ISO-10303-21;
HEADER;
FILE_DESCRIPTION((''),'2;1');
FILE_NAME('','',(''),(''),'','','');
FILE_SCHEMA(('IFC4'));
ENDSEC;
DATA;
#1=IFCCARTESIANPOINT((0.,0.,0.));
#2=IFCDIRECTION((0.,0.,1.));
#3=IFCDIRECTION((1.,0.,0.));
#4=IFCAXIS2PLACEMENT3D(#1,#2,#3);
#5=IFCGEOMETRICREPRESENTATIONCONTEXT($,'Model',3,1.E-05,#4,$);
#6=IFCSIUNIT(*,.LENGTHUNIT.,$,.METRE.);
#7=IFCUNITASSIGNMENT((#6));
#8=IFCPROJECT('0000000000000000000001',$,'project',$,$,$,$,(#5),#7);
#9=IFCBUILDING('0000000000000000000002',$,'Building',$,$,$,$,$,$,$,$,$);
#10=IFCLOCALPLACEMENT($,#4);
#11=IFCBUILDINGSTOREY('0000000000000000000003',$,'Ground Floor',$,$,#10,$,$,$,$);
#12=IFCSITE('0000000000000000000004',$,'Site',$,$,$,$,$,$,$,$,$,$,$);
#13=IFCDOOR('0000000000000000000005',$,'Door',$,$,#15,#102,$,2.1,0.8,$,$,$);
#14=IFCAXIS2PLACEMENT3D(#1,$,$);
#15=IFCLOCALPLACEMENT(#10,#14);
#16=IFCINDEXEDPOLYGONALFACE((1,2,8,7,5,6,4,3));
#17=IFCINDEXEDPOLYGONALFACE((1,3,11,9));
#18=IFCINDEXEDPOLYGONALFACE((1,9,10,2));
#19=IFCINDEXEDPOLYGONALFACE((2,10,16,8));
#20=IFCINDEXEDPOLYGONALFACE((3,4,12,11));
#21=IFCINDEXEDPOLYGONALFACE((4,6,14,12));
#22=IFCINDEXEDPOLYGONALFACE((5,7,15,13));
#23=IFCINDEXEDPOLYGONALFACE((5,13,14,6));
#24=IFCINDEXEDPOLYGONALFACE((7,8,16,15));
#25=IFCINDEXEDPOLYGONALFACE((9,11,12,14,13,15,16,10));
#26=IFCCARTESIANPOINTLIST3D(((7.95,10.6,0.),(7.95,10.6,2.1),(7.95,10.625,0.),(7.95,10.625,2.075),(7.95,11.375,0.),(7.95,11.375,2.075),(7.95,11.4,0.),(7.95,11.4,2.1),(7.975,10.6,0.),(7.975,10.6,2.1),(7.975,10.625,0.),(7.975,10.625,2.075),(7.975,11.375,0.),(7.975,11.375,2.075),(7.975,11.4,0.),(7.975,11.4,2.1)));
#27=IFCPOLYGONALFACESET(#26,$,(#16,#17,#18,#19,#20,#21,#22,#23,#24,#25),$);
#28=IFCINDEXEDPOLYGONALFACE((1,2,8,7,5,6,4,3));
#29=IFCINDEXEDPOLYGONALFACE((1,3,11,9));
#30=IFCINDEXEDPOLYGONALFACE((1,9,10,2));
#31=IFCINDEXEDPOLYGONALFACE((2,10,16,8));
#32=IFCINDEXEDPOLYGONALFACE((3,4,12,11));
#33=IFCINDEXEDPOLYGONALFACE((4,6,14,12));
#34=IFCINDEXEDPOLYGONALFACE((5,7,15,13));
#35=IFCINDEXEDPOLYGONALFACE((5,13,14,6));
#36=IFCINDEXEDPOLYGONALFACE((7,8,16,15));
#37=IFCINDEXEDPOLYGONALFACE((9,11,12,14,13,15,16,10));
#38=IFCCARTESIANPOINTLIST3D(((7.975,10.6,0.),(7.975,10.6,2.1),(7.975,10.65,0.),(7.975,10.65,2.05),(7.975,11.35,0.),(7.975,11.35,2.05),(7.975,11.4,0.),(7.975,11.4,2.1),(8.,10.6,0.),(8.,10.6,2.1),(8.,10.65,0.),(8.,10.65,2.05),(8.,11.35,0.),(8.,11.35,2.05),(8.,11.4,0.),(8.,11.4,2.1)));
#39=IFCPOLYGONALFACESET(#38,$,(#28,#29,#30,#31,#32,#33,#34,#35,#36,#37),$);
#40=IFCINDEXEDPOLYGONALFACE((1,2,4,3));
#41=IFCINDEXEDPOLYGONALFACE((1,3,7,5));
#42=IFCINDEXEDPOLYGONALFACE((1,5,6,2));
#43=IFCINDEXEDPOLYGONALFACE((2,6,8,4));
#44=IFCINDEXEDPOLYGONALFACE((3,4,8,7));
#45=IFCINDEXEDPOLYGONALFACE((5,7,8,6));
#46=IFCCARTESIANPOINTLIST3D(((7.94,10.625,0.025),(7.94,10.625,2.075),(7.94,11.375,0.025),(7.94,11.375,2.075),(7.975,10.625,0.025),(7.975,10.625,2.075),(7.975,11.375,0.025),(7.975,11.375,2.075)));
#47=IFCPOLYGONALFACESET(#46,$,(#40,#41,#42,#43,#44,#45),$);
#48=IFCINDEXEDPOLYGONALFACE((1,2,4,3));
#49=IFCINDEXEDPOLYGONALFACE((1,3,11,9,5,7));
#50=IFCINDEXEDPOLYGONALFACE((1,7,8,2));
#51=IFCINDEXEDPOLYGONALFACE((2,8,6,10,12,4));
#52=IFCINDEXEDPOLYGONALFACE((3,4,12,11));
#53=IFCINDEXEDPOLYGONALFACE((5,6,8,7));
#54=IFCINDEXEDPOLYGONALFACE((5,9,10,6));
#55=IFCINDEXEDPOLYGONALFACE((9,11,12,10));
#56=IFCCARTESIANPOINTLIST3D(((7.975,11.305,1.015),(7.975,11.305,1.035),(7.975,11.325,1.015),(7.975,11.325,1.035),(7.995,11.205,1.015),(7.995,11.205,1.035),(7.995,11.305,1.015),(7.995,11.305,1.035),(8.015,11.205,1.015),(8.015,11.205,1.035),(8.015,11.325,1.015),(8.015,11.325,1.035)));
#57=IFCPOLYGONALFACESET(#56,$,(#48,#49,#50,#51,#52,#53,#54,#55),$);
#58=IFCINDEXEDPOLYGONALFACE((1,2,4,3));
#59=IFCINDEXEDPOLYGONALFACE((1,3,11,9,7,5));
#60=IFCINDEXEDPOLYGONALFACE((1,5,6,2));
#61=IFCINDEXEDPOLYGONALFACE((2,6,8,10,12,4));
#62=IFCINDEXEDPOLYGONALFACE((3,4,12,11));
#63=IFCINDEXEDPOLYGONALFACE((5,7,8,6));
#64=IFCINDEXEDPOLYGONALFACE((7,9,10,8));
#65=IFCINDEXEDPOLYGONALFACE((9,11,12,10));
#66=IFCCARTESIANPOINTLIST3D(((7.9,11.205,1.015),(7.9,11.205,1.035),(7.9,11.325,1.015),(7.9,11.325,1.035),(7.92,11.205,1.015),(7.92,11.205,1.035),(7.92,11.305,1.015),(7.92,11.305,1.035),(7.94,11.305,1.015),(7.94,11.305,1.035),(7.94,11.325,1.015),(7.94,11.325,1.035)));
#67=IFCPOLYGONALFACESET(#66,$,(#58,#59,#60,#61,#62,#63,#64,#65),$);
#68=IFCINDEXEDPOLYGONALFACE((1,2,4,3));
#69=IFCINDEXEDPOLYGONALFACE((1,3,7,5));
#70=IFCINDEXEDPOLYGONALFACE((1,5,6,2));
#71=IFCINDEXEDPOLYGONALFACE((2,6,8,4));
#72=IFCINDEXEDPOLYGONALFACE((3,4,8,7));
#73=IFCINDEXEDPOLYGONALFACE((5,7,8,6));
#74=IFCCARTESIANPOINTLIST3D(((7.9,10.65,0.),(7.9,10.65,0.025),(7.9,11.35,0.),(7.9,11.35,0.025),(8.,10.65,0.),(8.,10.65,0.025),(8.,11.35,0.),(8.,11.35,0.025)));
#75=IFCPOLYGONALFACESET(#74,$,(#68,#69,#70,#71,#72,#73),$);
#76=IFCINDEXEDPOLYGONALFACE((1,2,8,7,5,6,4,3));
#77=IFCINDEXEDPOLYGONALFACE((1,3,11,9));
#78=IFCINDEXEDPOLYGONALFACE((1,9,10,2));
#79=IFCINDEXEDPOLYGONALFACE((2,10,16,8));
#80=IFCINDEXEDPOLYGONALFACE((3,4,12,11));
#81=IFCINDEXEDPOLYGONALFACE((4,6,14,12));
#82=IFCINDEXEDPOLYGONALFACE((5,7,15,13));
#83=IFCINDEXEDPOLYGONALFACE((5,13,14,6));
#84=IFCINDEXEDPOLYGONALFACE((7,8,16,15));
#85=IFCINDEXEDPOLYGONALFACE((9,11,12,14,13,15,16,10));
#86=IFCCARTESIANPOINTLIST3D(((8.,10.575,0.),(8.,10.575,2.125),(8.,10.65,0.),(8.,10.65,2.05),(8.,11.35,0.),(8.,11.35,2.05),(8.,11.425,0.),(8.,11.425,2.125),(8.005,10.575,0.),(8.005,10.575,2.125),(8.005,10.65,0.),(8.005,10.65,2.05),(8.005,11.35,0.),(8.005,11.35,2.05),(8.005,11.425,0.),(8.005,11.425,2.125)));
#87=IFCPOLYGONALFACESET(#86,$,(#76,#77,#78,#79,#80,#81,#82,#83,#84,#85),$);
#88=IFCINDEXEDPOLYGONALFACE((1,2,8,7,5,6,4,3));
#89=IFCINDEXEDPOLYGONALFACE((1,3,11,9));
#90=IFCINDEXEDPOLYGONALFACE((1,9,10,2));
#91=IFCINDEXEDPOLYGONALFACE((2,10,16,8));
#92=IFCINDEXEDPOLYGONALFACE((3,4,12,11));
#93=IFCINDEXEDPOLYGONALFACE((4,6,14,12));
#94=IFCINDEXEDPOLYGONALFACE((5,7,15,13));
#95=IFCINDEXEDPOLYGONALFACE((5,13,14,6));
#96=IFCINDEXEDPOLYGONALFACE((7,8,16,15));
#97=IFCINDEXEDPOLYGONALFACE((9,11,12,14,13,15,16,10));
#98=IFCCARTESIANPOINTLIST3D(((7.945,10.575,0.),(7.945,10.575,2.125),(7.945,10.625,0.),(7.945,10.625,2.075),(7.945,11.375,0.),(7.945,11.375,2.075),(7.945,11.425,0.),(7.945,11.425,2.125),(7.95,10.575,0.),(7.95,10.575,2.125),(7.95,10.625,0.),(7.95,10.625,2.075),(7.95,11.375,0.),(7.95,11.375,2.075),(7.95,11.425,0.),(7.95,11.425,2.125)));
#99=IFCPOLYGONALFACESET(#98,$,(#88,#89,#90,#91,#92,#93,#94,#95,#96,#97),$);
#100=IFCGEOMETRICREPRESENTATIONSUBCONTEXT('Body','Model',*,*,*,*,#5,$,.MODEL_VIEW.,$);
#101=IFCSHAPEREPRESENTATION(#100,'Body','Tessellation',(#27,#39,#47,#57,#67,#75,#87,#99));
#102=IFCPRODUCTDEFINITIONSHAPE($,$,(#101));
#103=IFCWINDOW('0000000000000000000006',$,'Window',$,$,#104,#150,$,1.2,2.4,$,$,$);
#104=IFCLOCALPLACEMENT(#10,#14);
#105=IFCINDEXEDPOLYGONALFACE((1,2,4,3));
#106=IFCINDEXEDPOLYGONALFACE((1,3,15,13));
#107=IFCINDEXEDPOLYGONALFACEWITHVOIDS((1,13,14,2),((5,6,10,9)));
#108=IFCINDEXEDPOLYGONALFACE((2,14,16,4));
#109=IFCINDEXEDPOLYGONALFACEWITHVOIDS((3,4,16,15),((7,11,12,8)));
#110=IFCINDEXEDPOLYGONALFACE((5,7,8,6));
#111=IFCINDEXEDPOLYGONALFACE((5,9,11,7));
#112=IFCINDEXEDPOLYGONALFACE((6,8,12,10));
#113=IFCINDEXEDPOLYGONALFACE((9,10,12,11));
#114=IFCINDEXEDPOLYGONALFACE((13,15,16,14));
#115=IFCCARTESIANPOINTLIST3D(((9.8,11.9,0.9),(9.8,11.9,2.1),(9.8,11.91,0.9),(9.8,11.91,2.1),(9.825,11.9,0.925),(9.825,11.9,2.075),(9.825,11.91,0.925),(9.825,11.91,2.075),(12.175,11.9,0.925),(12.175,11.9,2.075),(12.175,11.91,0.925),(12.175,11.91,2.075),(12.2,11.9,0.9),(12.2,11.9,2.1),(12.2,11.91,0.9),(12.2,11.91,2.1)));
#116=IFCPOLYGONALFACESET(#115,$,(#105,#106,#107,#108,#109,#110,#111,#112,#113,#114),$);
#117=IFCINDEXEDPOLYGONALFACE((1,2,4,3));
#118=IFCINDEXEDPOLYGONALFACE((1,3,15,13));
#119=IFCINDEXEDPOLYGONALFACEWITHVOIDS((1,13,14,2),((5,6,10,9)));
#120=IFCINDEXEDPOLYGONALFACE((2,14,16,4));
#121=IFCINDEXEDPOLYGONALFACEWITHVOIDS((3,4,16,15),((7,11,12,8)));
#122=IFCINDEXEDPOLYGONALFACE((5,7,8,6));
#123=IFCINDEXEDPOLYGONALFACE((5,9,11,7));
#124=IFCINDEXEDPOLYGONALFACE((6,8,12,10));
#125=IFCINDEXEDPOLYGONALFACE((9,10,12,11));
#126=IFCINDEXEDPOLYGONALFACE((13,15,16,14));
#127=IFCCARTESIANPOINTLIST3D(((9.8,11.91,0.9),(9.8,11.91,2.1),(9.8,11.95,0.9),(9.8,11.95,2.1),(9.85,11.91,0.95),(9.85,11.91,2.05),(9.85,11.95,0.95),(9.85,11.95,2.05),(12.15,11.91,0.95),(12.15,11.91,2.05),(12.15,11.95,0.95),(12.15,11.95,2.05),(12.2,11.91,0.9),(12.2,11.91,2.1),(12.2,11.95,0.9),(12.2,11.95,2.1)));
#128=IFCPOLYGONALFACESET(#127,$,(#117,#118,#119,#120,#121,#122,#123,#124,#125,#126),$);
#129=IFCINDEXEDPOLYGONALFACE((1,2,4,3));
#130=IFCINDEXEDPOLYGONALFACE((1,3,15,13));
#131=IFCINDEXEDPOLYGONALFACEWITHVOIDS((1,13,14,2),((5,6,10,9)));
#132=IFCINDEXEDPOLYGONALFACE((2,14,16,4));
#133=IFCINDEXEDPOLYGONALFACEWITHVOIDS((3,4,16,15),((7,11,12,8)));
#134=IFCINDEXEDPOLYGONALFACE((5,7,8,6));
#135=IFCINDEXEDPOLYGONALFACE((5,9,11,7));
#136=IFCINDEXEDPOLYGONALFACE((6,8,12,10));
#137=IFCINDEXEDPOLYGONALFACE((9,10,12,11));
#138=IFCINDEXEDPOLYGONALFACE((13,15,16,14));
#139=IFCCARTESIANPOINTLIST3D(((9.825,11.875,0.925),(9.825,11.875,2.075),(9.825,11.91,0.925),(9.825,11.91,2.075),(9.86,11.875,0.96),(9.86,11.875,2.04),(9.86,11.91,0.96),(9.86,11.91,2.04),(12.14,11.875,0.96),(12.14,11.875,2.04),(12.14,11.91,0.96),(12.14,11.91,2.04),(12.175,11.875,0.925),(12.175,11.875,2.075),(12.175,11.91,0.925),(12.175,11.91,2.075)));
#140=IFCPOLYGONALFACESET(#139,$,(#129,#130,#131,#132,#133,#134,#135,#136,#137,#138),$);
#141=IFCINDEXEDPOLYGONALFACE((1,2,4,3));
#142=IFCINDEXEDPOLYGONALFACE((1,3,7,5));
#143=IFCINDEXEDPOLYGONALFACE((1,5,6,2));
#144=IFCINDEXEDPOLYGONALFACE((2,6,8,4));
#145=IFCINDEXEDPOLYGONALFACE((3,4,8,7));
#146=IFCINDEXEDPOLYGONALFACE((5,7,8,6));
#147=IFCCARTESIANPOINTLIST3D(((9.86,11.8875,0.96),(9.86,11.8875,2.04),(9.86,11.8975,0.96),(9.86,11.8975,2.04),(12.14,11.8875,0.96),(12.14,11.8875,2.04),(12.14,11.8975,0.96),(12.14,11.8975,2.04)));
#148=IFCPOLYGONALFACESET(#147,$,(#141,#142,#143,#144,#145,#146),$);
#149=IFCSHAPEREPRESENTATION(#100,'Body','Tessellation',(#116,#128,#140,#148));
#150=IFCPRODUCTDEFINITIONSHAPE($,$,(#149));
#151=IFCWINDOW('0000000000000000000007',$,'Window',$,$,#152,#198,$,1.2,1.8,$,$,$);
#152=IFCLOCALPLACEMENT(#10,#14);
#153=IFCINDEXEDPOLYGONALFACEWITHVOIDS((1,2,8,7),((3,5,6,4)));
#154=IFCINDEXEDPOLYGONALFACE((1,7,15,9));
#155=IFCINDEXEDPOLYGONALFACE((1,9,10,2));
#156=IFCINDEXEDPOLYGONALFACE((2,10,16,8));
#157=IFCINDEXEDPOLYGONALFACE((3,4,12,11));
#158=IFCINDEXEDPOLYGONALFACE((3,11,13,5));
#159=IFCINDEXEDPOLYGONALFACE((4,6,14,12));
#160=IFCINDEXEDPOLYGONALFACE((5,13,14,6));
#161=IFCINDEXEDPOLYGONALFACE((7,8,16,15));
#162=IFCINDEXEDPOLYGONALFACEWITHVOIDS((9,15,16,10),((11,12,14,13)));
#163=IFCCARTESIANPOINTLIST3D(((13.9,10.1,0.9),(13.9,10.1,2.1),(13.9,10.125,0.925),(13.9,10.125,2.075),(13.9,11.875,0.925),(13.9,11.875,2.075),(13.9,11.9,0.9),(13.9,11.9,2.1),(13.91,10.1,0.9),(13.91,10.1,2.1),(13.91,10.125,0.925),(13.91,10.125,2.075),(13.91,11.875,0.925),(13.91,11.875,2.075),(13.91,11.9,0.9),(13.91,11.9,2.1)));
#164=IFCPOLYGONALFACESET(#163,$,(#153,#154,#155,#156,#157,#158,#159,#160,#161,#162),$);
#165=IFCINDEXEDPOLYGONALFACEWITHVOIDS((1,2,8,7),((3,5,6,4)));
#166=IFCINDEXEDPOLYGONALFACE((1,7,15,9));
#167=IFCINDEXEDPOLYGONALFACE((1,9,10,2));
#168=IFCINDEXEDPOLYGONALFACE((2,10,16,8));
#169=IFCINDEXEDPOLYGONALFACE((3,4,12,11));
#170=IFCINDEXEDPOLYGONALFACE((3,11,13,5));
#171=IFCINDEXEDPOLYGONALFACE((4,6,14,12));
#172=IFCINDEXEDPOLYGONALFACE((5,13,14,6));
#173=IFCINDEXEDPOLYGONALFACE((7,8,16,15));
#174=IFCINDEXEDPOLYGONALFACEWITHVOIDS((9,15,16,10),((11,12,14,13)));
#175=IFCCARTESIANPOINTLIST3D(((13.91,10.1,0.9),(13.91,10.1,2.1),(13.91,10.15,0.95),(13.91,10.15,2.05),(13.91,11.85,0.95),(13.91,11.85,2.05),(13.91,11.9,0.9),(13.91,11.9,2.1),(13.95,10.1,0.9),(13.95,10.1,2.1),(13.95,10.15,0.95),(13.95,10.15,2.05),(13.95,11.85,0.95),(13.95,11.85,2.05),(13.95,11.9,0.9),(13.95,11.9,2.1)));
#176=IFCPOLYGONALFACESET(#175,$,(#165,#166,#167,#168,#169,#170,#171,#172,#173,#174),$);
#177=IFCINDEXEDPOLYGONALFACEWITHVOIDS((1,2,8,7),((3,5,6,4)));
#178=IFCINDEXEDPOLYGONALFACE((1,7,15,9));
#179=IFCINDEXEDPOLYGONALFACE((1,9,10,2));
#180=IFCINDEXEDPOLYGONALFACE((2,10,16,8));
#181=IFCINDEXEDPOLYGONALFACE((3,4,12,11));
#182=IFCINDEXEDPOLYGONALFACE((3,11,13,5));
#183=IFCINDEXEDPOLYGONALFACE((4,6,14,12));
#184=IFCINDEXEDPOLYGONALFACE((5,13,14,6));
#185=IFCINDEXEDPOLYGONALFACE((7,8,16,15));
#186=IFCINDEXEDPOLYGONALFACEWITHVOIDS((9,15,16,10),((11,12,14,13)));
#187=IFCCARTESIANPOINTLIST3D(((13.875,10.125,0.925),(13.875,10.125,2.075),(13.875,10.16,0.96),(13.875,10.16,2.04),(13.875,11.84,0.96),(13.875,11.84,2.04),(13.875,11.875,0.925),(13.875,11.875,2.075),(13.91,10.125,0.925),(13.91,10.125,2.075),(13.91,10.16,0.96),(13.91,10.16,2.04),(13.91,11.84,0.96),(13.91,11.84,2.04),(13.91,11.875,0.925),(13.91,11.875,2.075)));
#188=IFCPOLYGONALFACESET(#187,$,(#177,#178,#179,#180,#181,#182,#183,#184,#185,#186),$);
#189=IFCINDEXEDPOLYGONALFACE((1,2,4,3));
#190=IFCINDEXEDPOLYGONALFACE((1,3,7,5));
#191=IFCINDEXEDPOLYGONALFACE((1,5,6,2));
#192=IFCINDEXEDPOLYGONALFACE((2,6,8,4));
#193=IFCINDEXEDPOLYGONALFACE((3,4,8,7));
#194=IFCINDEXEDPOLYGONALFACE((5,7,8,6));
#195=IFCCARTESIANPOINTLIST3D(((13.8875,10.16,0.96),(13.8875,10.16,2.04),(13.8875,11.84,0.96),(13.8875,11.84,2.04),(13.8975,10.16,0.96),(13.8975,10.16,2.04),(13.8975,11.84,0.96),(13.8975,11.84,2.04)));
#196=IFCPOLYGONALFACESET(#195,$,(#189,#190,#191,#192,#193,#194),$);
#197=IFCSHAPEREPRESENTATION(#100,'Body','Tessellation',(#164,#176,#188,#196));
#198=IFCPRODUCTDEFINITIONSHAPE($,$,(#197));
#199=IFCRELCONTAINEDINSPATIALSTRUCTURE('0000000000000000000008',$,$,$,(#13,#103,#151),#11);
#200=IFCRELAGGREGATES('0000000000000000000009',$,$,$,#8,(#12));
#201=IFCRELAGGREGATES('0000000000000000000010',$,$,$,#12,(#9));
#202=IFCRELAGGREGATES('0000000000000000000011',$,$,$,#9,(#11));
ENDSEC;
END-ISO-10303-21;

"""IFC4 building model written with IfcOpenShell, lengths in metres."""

from ifc_helpers import new_model, si_unit, frame, origin_with_axes, place, context, subcontext, project, spatial, line, indexed_curve, outline, extrude, element, save


model = new_model("IFC4")

# Units and contexts
model_context = context("Model", 3, precision=1e-05, world=origin_with_axes())
body_context = subcontext(model_context, "Body", "Model", "MODEL_VIEW")
ifc_project = project(units=[si_unit("LENGTHUNIT", "METRE")], contexts=[model_context])

# Site, building, storey
site = spatial("IfcSite", under=ifc_project, Name="Site")
building = spatial("IfcBuilding", under=site, Name="Building")
storey_placement = place(None, origin_with_axes())
storey = spatial("IfcBuildingStorey", under=building, at=storey_placement, Name="Ground Floor")

# Door
door_1_placement = place(storey_placement, frame((8.0, 10.6, 0.0), z_axis=(0.0, 0.0, 1.0), x_axis=(0.0, 1.0, 0.0)))
element("IfcDoor", 1, at=door_1_placement, inside=storey, Name="Door", OverallHeight=2.1, OverallWidth=0.8, context=body_context, shape_type="SweptSolid", body=[
    extrude(outline(indexed_curve([(0.0, 0.0), (0.0, 2.1), (0.8, 2.1), (0.8, 0.0), (0.775, 0.0), (0.775, 2.075), (0.025, 2.075), (0.025, 0.0)], segments=[line(1, 2, 3, 4, 5, 6, 7, 8, 1)])), frame((0.0, 0.025, 0.0), z_axis=(0.0, -1.0, 0.0), x_axis=(1.0, 0.0, 0.0)), (0.0, 0.0, -1.0), 0.025),
    extrude(outline(indexed_curve([(0.0, 0.0), (0.0, 2.1), (0.8, 2.1), (0.8, 0.0), (0.75, 0.0), (0.75, 2.05), (0.05, 2.05), (0.05, 0.0)], segments=[line(1, 2, 3, 4, 5, 6, 7, 8, 1)])), frame((0.0, 0.0, 0.0), z_axis=(0.0, -1.0, 0.0), x_axis=(1.0, 0.0, 0.0)), (0.0, 0.0, -1.0), 0.025),
    extrude(outline(indexed_curve([(0.0, 0.0), (0.75, 0.0), (0.75, 0.035), (0.0, 0.035)], segments=[line(1, 2, 3, 4, 1)])), frame((0.025, 0.025, 0.025), z_axis=(0.0, 0.0, 1.0), x_axis=(1.0, 0.0, 0.0)), (0.0, 0.0, 1.0), 2.05),
    extrude(outline(indexed_curve([(0.0, 0.0), (0.0, -0.04), (-0.12, -0.04), (-0.12, -0.02), (-0.02, -0.02), (-0.02, 0.0)], segments=[line(1, 2, 3, 4, 5, 6, 1)])), frame((0.725, 0.025, 1.015), z_axis=(0.0, 0.0, 1.0), x_axis=(1.0, 0.0, 0.0)), (0.0, 0.0, 1.0), 0.02),
    extrude(outline(indexed_curve([(0.0, 0.0), (0.0, 0.04), (-0.12, 0.04), (-0.12, 0.02), (-0.02, 0.02), (-0.02, 0.0)], segments=[line(1, 2, 3, 4, 5, 6, 1)])), frame((0.725, 0.06, 1.015), z_axis=(0.0, 0.0, 1.0), x_axis=(1.0, 0.0, 0.0)), (0.0, 0.0, 1.0), 0.02),
    extrude(outline(indexed_curve([(0.0, 0.0), (0.7, 0.0), (0.7, 0.1), (0.0, 0.1)], segments=[line(1, 2, 3, 4, 1)])), frame((0.05, 0.0, 0.0), z_axis=(0.0, 0.0, 1.0), x_axis=(1.0, 0.0, 0.0)), (0.0, 0.0, 1.0), 0.025),
    extrude(outline(indexed_curve([(0.0, 0.0), (0.0, 2.125), (0.85, 2.125), (0.85, 0.0), (0.775, 0.0), (0.775, 2.05), (0.075, 2.05), (0.075, 0.0)], segments=[line(1, 2, 3, 4, 5, 6, 7, 8, 1)])), frame((-0.025, -0.005, 0.0), z_axis=(0.0, -1.0, 0.0), x_axis=(1.0, 0.0, 0.0)), (0.0, 0.0, -1.0), 0.005),
    extrude(outline(indexed_curve([(0.0, 0.0), (0.0, 2.125), (0.85, 2.125), (0.85, 0.0), (0.8, 0.0), (0.8, 2.075), (0.05, 2.075), (0.05, 0.0)], segments=[line(1, 2, 3, 4, 5, 6, 7, 8, 1)])), frame((-0.025, 0.05, 0.0), z_axis=(0.0, -1.0, 0.0), x_axis=(1.0, 0.0, 0.0)), (0.0, 0.0, -1.0), 0.005),
])

# Windows
window_1_placement = place(storey_placement, frame((12.2, 12.0, 0.9), z_axis=(0.0, 0.0, 1.0), x_axis=(-1.0, 0.0, 0.0)))
element("IfcWindow", 2, at=window_1_placement, inside=storey, Name="Window", OverallHeight=1.2, OverallWidth=2.4, context=body_context, shape_type="SweptSolid", body=[
    extrude(outline(indexed_curve([(0.0, 0.0), (2.4, 0.0), (2.4, 1.2), (0.0, 1.2)], segments=[line(1, 2, 3, 4, 1)]), holes=[indexed_curve([(0.025, 0.025), (2.375, 0.025), (2.375, 1.175), (0.025, 1.175)], segments=[line(1, 2, 3, 4, 1)])]), frame((0.0, 0.09, 0.0), z_axis=(0.0, -1.0, 0.0), x_axis=(1.0, 0.0, 0.0)), (0.0, 0.0, -1.0), 0.01),
    extrude(outline(indexed_curve([(0.0, 0.0), (2.4, 0.0), (2.4, 1.2), (0.0, 1.2)], segments=[line(1, 2, 3, 4, 1)]), holes=[indexed_curve([(0.05, 0.05), (2.35, 0.05), (2.35, 1.15), (0.05, 1.15)], segments=[line(1, 2, 3, 4, 1)])]), frame((0.0, 0.05, 0.0), z_axis=(0.0, -1.0, 0.0), x_axis=(1.0, 0.0, 0.0)), (0.0, 0.0, -1.0), 0.04),
    extrude(outline(indexed_curve([(0.0, 0.0), (2.35, 0.0), (2.35, 1.15), (0.0, 1.15)], segments=[line(1, 2, 3, 4, 1)]), holes=[indexed_curve([(0.035, 0.035), (2.315, 0.035), (2.315, 1.115), (0.035, 1.115)], segments=[line(1, 2, 3, 4, 1)])]), frame((0.025, 0.09, 0.025), z_axis=(0.0, -1.0, 0.0), x_axis=(1.0, 0.0, 0.0)), (0.0, 0.0, -1.0), 0.035),
    extrude(outline(indexed_curve([(0.035, 0.035), (2.315, 0.035), (2.315, 1.115), (0.035, 1.115)], segments=[line(1, 2, 3, 4, 1)])), frame((0.025, 0.1025, 0.025), z_axis=(0.0, -1.0, 0.0), x_axis=(1.0, 0.0, 0.0)), (0.0, 0.0, -1.0), 0.01),
])
window_2_placement = place(storey_placement, frame((14.0, 10.1, 0.9), z_axis=(0.0, 0.0, 1.0), x_axis=(0.0, 1.0, 0.0)))
element("IfcWindow", 3, at=window_2_placement, inside=storey, Name="Window", OverallHeight=1.2, OverallWidth=1.8, context=body_context, shape_type="SweptSolid", body=[
    extrude(outline(indexed_curve([(0.0, 0.0), (1.8, 0.0), (1.8, 1.2), (0.0, 1.2)], segments=[line(1, 2, 3, 4, 1)]), holes=[indexed_curve([(0.025, 0.025), (1.775, 0.025), (1.775, 1.175), (0.025, 1.175)], segments=[line(1, 2, 3, 4, 1)])]), frame((0.0, 0.09, 0.0), z_axis=(0.0, -1.0, 0.0), x_axis=(1.0, 0.0, 0.0)), (0.0, 0.0, -1.0), 0.01),
    extrude(outline(indexed_curve([(0.0, 0.0), (1.8, 0.0), (1.8, 1.2), (0.0, 1.2)], segments=[line(1, 2, 3, 4, 1)]), holes=[indexed_curve([(0.05, 0.05), (1.75, 0.05), (1.75, 1.15), (0.05, 1.15)], segments=[line(1, 2, 3, 4, 1)])]), frame((0.0, 0.05, 0.0), z_axis=(0.0, -1.0, 0.0), x_axis=(1.0, 0.0, 0.0)), (0.0, 0.0, -1.0), 0.04),
    extrude(outline(indexed_curve([(0.0, 0.0), (1.75, 0.0), (1.75, 1.15), (0.0, 1.15)], segments=[line(1, 2, 3, 4, 1)]), holes=[indexed_curve([(0.035, 0.035), (1.715, 0.035), (1.715, 1.115), (0.035, 1.115)], segments=[line(1, 2, 3, 4, 1)])]), frame((0.025, 0.09, 0.025), z_axis=(0.0, -1.0, 0.0), x_axis=(1.0, 0.0, 0.0)), (0.0, 0.0, -1.0), 0.035),
    extrude(outline(indexed_curve([(0.035, 0.035), (1.715, 0.035), (1.715, 1.115), (0.035, 1.115)], segments=[line(1, 2, 3, 4, 1)])), frame((0.025, 0.1025, 0.025), z_axis=(0.0, -1.0, 0.0), x_axis=(1.0, 0.0, 0.0)), (0.0, 0.0, -1.0), 0.01),
])

save(model, "model.ifc")
